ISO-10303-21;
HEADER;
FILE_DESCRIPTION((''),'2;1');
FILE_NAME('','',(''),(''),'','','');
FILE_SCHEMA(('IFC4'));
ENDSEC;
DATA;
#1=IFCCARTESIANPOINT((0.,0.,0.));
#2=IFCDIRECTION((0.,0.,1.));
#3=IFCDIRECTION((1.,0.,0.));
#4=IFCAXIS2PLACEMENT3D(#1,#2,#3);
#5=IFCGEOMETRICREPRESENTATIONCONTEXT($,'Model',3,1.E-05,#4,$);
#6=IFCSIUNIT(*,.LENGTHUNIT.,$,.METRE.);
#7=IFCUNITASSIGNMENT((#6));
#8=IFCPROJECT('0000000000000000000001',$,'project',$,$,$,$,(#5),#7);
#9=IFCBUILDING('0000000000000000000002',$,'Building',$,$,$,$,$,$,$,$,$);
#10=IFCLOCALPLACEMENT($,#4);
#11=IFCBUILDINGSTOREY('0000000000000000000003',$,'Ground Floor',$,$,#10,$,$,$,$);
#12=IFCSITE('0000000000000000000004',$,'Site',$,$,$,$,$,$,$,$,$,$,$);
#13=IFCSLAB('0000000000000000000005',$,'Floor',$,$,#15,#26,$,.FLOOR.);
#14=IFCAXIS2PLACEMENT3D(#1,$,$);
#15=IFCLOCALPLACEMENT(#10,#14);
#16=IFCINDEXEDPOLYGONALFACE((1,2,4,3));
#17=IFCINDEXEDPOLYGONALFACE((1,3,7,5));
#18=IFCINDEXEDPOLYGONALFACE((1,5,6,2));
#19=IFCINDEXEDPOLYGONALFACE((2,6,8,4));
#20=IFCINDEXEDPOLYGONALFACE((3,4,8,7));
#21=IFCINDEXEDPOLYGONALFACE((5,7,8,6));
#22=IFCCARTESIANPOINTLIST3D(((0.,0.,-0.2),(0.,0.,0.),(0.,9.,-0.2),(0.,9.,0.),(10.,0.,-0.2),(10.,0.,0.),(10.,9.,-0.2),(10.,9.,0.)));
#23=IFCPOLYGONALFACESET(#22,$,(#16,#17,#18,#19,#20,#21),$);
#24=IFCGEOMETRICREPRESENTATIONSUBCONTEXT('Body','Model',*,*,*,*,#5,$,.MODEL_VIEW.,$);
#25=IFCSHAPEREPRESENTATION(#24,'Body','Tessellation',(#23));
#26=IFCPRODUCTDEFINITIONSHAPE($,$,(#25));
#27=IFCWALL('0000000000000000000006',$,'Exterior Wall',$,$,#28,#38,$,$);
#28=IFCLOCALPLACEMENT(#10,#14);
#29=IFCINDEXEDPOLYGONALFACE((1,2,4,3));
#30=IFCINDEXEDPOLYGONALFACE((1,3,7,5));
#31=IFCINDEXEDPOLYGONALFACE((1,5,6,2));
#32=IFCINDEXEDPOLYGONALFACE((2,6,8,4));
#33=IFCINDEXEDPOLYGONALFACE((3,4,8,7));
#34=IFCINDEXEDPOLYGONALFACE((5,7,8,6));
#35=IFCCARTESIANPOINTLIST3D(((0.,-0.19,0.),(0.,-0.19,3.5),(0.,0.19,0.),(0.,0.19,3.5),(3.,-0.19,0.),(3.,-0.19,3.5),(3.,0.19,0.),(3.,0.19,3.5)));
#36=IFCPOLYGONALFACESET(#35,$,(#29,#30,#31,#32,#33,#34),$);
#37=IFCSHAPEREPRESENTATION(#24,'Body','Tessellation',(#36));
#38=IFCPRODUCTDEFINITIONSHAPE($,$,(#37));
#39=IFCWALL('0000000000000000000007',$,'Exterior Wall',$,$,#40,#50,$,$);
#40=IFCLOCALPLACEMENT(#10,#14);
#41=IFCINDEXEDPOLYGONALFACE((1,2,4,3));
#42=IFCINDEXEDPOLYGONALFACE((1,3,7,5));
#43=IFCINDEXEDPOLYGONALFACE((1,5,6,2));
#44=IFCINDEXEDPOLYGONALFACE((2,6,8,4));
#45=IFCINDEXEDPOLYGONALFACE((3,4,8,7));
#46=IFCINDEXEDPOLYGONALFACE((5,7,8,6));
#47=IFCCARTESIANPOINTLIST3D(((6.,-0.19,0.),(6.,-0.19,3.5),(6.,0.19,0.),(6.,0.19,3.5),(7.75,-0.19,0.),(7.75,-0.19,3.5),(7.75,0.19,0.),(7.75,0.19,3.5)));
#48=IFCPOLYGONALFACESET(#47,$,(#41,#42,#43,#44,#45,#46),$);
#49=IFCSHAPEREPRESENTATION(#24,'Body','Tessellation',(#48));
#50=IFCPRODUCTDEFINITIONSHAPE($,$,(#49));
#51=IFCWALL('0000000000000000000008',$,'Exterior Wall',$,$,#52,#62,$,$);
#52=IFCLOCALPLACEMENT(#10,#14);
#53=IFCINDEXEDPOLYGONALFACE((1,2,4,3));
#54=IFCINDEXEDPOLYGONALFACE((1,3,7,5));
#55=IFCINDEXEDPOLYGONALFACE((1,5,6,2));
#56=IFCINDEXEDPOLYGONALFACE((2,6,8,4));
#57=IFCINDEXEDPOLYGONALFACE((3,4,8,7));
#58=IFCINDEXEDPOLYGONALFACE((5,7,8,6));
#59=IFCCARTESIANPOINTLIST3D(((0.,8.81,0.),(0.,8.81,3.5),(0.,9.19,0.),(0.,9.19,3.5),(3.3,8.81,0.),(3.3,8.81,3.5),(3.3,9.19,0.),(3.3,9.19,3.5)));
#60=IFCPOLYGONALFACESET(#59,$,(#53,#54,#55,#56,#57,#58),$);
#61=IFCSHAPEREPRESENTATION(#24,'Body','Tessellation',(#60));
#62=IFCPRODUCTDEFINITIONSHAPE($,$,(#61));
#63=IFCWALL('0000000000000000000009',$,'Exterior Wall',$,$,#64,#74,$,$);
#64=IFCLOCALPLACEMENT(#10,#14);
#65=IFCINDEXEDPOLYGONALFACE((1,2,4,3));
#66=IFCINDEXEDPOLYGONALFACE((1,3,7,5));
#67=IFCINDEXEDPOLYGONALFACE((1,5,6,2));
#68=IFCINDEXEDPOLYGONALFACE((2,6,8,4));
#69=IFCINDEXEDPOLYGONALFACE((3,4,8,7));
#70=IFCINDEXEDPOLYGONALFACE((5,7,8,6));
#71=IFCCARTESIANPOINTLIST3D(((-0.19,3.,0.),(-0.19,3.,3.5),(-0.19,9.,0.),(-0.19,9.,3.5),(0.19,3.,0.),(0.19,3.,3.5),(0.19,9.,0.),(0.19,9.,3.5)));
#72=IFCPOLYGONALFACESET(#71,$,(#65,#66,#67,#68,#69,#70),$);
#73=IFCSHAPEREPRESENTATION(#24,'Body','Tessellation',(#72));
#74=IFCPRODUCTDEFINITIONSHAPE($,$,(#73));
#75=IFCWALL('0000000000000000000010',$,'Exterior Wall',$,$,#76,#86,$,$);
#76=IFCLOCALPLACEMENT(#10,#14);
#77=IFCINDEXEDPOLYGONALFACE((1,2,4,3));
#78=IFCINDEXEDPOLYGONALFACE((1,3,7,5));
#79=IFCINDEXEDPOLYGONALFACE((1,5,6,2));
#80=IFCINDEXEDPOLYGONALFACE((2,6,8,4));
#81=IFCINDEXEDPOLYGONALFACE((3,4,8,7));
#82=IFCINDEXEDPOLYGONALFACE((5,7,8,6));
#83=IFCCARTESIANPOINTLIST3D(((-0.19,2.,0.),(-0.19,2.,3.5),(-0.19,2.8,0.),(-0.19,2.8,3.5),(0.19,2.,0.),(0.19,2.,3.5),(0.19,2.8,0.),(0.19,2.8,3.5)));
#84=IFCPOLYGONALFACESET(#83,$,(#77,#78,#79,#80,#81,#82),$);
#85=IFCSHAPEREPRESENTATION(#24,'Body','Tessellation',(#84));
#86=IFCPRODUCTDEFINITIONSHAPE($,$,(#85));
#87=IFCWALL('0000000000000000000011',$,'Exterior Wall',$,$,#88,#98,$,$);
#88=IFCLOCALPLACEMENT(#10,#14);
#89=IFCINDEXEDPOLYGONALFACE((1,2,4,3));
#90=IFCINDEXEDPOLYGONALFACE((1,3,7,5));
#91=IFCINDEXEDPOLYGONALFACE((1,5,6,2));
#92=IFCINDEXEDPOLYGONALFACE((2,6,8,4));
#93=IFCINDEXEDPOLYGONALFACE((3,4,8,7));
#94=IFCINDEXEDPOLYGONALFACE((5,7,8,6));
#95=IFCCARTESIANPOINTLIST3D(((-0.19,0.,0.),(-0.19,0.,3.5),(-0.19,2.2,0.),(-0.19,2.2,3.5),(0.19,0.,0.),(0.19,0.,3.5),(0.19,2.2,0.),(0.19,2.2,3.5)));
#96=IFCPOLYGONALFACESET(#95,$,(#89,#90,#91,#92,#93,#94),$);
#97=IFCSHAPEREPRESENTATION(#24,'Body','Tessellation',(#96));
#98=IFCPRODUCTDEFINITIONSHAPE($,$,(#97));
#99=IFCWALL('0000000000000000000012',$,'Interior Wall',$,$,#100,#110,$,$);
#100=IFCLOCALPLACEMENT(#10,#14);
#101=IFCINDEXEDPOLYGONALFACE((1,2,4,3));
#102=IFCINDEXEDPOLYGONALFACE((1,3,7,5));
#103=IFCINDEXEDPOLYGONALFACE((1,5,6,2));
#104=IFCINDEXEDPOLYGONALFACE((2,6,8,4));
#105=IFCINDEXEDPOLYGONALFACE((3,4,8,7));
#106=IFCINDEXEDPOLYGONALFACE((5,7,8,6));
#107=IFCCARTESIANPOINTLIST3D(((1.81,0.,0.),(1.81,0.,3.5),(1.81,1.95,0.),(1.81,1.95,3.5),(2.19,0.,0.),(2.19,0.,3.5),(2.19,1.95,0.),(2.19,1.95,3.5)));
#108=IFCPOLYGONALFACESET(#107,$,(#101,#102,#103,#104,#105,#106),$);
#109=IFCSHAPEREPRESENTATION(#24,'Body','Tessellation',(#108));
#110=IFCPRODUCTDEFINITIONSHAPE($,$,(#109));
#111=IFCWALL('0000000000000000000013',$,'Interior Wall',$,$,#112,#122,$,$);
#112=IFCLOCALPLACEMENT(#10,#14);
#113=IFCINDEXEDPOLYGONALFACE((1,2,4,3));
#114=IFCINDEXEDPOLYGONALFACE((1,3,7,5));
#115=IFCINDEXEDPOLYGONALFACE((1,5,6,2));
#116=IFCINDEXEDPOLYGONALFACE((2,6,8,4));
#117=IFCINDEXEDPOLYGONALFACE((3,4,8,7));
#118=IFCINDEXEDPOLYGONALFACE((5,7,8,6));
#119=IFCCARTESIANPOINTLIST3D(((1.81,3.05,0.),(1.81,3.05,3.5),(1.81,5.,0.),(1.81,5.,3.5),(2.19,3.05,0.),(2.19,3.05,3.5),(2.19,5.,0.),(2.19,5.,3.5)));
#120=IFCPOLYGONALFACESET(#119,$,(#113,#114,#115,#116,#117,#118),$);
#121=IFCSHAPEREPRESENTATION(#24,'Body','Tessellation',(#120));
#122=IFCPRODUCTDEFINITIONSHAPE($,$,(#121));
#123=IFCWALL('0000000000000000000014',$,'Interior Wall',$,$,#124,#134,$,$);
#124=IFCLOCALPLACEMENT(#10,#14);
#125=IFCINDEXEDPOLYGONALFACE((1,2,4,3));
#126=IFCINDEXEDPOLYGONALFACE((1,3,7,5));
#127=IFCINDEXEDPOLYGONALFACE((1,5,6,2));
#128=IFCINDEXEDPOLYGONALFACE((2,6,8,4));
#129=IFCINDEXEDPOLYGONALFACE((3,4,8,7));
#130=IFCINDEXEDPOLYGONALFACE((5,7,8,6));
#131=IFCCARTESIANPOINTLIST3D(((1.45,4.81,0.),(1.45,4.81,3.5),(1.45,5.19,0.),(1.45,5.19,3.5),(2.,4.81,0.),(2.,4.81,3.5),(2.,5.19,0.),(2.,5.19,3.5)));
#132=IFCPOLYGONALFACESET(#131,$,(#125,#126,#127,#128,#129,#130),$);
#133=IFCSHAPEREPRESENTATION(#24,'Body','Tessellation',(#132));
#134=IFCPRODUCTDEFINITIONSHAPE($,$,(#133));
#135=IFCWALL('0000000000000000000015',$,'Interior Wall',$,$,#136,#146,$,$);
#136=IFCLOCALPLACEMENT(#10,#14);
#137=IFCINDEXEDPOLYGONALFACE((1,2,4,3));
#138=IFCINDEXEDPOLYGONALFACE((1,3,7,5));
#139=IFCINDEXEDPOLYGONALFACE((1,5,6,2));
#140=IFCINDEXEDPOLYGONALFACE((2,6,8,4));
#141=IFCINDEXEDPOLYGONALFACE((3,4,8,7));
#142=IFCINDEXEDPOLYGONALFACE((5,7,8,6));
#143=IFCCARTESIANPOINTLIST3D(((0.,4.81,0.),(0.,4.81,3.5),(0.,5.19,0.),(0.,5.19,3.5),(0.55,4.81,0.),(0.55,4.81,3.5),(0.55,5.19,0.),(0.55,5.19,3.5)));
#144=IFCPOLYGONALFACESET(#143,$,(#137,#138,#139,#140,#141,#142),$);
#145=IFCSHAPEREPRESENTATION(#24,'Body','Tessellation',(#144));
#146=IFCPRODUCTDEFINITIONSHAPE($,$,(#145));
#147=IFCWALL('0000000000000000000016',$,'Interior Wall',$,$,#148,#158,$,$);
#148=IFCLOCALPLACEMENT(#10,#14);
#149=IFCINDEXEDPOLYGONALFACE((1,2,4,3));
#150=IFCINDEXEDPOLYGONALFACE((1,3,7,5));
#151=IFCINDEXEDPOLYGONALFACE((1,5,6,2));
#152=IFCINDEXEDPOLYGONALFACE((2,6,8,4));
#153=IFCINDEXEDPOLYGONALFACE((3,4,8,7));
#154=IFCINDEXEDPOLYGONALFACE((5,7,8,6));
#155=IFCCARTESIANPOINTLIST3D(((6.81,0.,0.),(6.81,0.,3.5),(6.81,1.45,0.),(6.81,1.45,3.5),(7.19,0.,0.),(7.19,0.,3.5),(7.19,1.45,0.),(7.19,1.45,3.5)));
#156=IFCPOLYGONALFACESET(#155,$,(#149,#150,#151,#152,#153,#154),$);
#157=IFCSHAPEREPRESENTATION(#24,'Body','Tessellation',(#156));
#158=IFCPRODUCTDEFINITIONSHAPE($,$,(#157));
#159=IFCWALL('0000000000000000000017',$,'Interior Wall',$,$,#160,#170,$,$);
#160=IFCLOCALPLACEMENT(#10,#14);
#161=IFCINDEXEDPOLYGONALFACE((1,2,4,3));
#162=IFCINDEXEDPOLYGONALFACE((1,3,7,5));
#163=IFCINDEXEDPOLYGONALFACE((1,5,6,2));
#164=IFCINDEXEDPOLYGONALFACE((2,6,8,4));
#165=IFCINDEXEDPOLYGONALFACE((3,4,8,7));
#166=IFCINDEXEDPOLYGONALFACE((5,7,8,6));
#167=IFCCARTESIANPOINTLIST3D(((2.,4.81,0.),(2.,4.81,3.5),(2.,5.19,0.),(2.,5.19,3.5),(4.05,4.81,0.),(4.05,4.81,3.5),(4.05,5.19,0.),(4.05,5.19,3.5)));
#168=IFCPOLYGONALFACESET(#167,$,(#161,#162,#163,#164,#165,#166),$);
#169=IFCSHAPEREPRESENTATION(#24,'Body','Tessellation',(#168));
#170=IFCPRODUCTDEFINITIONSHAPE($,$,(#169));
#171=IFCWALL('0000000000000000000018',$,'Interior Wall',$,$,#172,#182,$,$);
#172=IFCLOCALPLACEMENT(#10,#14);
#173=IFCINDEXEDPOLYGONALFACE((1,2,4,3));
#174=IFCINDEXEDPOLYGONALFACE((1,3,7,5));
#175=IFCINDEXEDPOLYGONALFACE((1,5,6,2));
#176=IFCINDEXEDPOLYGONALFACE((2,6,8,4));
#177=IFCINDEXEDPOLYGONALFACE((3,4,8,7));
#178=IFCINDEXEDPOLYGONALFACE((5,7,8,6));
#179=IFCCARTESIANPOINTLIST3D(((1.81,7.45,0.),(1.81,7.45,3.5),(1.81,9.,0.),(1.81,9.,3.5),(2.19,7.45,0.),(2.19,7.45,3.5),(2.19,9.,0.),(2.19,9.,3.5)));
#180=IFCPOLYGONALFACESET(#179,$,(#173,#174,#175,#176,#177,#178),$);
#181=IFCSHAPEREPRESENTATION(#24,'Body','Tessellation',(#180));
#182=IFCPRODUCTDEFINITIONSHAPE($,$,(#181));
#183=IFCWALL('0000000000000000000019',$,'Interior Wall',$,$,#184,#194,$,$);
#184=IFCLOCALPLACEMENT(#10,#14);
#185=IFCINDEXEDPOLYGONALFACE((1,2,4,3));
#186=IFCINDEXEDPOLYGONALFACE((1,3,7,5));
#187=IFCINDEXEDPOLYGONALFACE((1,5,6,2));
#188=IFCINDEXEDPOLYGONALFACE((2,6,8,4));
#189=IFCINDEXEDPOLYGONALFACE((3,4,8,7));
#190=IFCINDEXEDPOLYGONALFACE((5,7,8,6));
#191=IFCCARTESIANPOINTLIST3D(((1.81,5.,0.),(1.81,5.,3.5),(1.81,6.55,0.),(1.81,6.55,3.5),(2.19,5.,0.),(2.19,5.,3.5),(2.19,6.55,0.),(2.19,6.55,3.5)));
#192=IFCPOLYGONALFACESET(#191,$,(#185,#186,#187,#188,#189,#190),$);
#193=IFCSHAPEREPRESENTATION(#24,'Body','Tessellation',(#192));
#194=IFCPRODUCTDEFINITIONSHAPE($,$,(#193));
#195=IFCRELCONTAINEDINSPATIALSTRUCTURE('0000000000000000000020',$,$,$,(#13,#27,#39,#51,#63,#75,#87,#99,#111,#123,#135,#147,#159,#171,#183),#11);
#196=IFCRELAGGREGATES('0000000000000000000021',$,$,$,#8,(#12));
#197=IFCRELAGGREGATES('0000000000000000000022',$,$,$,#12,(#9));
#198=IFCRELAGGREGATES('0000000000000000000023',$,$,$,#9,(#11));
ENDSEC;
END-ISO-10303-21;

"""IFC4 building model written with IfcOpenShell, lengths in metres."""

from ifc_helpers import new_model, si_unit, frame, origin_with_axes, place, context, subcontext, project, spatial, indexed_curve, outline, extrude, element, save


model = new_model("IFC4")

# Units and contexts
model_context = context("Model", 3, precision=1e-05, world=origin_with_axes())
body_context = subcontext(model_context, "Body", "Model", "MODEL_VIEW")
ifc_project = project(units=[si_unit("LENGTHUNIT", "METRE")], contexts=[model_context])

# Site, building, storey
site = spatial("IfcSite", under=ifc_project, Name="Site")
building = spatial("IfcBuilding", under=site, Name="Building")
storey_placement = place(None, origin_with_axes())
storey = spatial("IfcBuildingStorey", under=building, at=storey_placement, Name="Ground Floor")

# Slab
slab_placement = place(storey_placement, frame((0.0, 0.0, -0.2), z_axis=(0.0, 0.0, 1.0), x_axis=(1.0, 0.0, 0.0)))
element("IfcSlab", 1, at=slab_placement, inside=storey, Name="Floor", PredefinedType="FLOOR", context=body_context, shape_type="SweptSolid", body=[
    extrude(outline(indexed_curve([(0.0, 0.0), (10.0, 0.0), (10.0, 9.0), (0.0, 9.0)])), None, (0.0, 0.0, 1.0), 0.2),
])

# Walls
wall_1_placement = place(storey_placement, origin_with_axes())
element("IfcWall", 2, at=wall_1_placement, inside=storey, Name="Exterior Wall", context=body_context, shape_type="SweptSolid", body=[
    extrude(outline(indexed_curve([(0.0, 0.0), (0.0, 0.38), (3.0, 0.38), (3.0, 0.0), (0.0, 0.0)], self_intersect=False)), frame((0.0, -0.19, 0.0), z_axis=(0.0, 0.0, 1.0), x_axis=(1.0, 0.0, 0.0)), (0.0, 0.0, 1.0), 3.5),
])
wall_2_placement = place(storey_placement, frame((6.0, 0.0, 0.0), z_axis=(0.0, 0.0, 1.0), x_axis=(1.0, 0.0, 0.0)))
element("IfcWall", 3, at=wall_2_placement, inside=storey, Name="Exterior Wall", context=body_context, shape_type="SweptSolid", body=[
    extrude(outline(indexed_curve([(0.0, 0.0), (0.0, 0.38), (1.75, 0.38), (1.75, 0.0), (0.0, 0.0)], self_intersect=False)), frame((0.0, -0.19, 0.0), z_axis=(0.0, 0.0, 1.0), x_axis=(1.0, 0.0, 0.0)), (0.0, 0.0, 1.0), 3.5),
])
wall_3_placement = place(storey_placement, frame((3.3, 9.0, 0.0), z_axis=(0.0, 0.0, 1.0), x_axis=(-1.0, 0.0, 0.0)))
element("IfcWall", 4, at=wall_3_placement, inside=storey, Name="Exterior Wall", context=body_context, shape_type="SweptSolid", body=[
    extrude(outline(indexed_curve([(0.0, 0.0), (0.0, 0.38), (3.3, 0.38), (3.3, 0.0), (0.0, 0.0)], self_intersect=False)), frame((0.0, -0.19, 0.0), z_axis=(0.0, 0.0, 1.0), x_axis=(1.0, 0.0, 0.0)), (0.0, 0.0, 1.0), 3.5),
])
wall_4_placement = place(storey_placement, frame((0.0, 9.0, 0.0), z_axis=(0.0, 0.0, 1.0), x_axis=(0.0, -1.0, 0.0)))
element("IfcWall", 5, at=wall_4_placement, inside=storey, Name="Exterior Wall", context=body_context, shape_type="SweptSolid", body=[
    extrude(outline(indexed_curve([(0.0, 0.0), (0.0, 0.38), (6.0, 0.38), (6.0, 0.0), (0.0, 0.0)], self_intersect=False)), frame((0.0, -0.19, 0.0), z_axis=(0.0, 0.0, 1.0), x_axis=(1.0, 0.0, 0.0)), (0.0, 0.0, 1.0), 3.5),
])
wall_5_placement = place(storey_placement, frame((0.0, 2.0, 0.0), z_axis=(0.0, 0.0, 1.0), x_axis=(0.0, 1.0, 0.0)))
element("IfcWall", 6, at=wall_5_placement, inside=storey, Name="Exterior Wall", context=body_context, shape_type="SweptSolid", body=[
    extrude(outline(indexed_curve([(0.0, 0.0), (0.0, 0.38), (0.8, 0.38), (0.8, 0.0), (0.0, 0.0)], self_intersect=False)), frame((0.0, -0.19, 0.0), z_axis=(0.0, 0.0, 1.0), x_axis=(1.0, 0.0, 0.0)), (0.0, 0.0, 1.0), 3.5),
])
wall_6_placement = place(storey_placement, frame((0.0, 2.2, 0.0), z_axis=(0.0, 0.0, 1.0), x_axis=(0.0, -1.0, 0.0)))
element("IfcWall", 7, at=wall_6_placement, inside=storey, Name="Exterior Wall", context=body_context, shape_type="SweptSolid", body=[
    extrude(outline(indexed_curve([(0.0, 0.0), (0.0, 0.38), (2.2, 0.38), (2.2, 0.0), (0.0, 0.0)], self_intersect=False)), frame((0.0, -0.19, 0.0), z_axis=(0.0, 0.0, 1.0), x_axis=(1.0, 0.0, 0.0)), (0.0, 0.0, 1.0), 3.5),
])
wall_7_placement = place(storey_placement, frame((2.0, 0.0, 0.0), z_axis=(0.0, 0.0, 1.0), x_axis=(0.0, 1.0, 0.0)))
element("IfcWall", 8, at=wall_7_placement, inside=storey, Name="Interior Wall", context=body_context, shape_type="SweptSolid", body=[
    extrude(outline(indexed_curve([(0.0, 0.0), (0.0, 0.38), (1.95, 0.38), (1.95, 0.0), (0.0, 0.0)], self_intersect=False)), frame((0.0, -0.19, 0.0), z_axis=(0.0, 0.0, 1.0), x_axis=(1.0, 0.0, 0.0)), (0.0, 0.0, 1.0), 3.5),
])
wall_8_placement = place(storey_placement, frame((2.0, 3.05, 0.0), z_axis=(0.0, 0.0, 1.0), x_axis=(0.0, 1.0, 0.0)))
element("IfcWall", 9, at=wall_8_placement, inside=storey, Name="Interior Wall", context=body_context, shape_type="SweptSolid", body=[
    extrude(outline(indexed_curve([(0.0, 0.0), (0.0, 0.38), (1.95, 0.38), (1.95, 0.0), (0.0, 0.0)], self_intersect=False)), frame((0.0, -0.19, 0.0), z_axis=(0.0, 0.0, 1.0), x_axis=(1.0, 0.0, 0.0)), (0.0, 0.0, 1.0), 3.5),
])
for number, where, z_axis, x_axis, name in (
    (10, (2.0, 5.0, 0.0), (0.0, 0.0, 1.0), (-1.0, 0.0, 0.0), "Interior Wall"),
    (11, (0.55, 5.0, 0.0), (0.0, 0.0, 1.0), (-1.0, 0.0, 0.0), "Interior Wall"),
):
    element("IfcWall", number, at=place(storey_placement, frame(where, z_axis=z_axis, x_axis=x_axis)), inside=storey, Name=name, context=body_context, shape_type="SweptSolid", body=[
        extrude(outline(indexed_curve([(0.0, 0.0), (0.0, 0.38), (0.55, 0.38), (0.55, 0.0), (0.0, 0.0)], self_intersect=False)), frame((0.0, -0.19, 0.0), z_axis=(0.0, 0.0, 1.0), x_axis=(1.0, 0.0, 0.0)), (0.0, 0.0, 1.0), 3.5),
    ])
wall_9_placement = place(storey_placement, frame((7.0, 0.0, 0.0), z_axis=(0.0, 0.0, 1.0), x_axis=(0.0, 1.0, 0.0)))
element("IfcWall", 12, at=wall_9_placement, inside=storey, Name="Interior Wall", context=body_context, shape_type="SweptSolid", body=[
    extrude(outline(indexed_curve([(0.0, 0.0), (0.0, 0.38), (1.45, 0.38), (1.45, 0.0), (0.0, 0.0)], self_intersect=False)), frame((0.0, -0.19, 0.0), z_axis=(0.0, 0.0, 1.0), x_axis=(1.0, 0.0, 0.0)), (0.0, 0.0, 1.0), 3.5),
])
wall_10_placement = place(storey_placement, frame((4.05, 5.0, 0.0), z_axis=(0.0, 0.0, 1.0), x_axis=(-1.0, 0.0, 0.0)))
element("IfcWall", 13, at=wall_10_placement, inside=storey, Name="Interior Wall", context=body_context, shape_type="SweptSolid", body=[
    extrude(outline(indexed_curve([(0.0, 0.0), (0.0, 0.38), (2.05, 0.38), (2.05, 0.0), (0.0, 0.0)], self_intersect=False)), frame((0.0, -0.19, 0.0), z_axis=(0.0, 0.0, 1.0), x_axis=(1.0, 0.0, 0.0)), (0.0, 0.0, 1.0), 3.5),
])
for number, where, z_axis, x_axis, name in (
    (14, (2.0, 9.0, 0.0), (0.0, 0.0, 1.0), (0.0, -1.0, 0.0), "Interior Wall"),
    (15, (2.0, 6.55, 0.0), (0.0, 0.0, 1.0), (0.0, -1.0, 0.0), "Interior Wall"),
):
    element("IfcWall", number, at=place(storey_placement, frame(where, z_axis=z_axis, x_axis=x_axis)), inside=storey, Name=name, context=body_context, shape_type="SweptSolid", body=[
        extrude(outline(indexed_curve([(0.0, 0.0), (0.0, 0.38), (1.55, 0.38), (1.55, 0.0), (0.0, 0.0)], self_intersect=False)), frame((0.0, -0.19, 0.0), z_axis=(0.0, 0.0, 1.0), x_axis=(1.0, 0.0, 0.0)), (0.0, 0.0, 1.0), 3.5),
    ])

save(model, "model.ifc")
